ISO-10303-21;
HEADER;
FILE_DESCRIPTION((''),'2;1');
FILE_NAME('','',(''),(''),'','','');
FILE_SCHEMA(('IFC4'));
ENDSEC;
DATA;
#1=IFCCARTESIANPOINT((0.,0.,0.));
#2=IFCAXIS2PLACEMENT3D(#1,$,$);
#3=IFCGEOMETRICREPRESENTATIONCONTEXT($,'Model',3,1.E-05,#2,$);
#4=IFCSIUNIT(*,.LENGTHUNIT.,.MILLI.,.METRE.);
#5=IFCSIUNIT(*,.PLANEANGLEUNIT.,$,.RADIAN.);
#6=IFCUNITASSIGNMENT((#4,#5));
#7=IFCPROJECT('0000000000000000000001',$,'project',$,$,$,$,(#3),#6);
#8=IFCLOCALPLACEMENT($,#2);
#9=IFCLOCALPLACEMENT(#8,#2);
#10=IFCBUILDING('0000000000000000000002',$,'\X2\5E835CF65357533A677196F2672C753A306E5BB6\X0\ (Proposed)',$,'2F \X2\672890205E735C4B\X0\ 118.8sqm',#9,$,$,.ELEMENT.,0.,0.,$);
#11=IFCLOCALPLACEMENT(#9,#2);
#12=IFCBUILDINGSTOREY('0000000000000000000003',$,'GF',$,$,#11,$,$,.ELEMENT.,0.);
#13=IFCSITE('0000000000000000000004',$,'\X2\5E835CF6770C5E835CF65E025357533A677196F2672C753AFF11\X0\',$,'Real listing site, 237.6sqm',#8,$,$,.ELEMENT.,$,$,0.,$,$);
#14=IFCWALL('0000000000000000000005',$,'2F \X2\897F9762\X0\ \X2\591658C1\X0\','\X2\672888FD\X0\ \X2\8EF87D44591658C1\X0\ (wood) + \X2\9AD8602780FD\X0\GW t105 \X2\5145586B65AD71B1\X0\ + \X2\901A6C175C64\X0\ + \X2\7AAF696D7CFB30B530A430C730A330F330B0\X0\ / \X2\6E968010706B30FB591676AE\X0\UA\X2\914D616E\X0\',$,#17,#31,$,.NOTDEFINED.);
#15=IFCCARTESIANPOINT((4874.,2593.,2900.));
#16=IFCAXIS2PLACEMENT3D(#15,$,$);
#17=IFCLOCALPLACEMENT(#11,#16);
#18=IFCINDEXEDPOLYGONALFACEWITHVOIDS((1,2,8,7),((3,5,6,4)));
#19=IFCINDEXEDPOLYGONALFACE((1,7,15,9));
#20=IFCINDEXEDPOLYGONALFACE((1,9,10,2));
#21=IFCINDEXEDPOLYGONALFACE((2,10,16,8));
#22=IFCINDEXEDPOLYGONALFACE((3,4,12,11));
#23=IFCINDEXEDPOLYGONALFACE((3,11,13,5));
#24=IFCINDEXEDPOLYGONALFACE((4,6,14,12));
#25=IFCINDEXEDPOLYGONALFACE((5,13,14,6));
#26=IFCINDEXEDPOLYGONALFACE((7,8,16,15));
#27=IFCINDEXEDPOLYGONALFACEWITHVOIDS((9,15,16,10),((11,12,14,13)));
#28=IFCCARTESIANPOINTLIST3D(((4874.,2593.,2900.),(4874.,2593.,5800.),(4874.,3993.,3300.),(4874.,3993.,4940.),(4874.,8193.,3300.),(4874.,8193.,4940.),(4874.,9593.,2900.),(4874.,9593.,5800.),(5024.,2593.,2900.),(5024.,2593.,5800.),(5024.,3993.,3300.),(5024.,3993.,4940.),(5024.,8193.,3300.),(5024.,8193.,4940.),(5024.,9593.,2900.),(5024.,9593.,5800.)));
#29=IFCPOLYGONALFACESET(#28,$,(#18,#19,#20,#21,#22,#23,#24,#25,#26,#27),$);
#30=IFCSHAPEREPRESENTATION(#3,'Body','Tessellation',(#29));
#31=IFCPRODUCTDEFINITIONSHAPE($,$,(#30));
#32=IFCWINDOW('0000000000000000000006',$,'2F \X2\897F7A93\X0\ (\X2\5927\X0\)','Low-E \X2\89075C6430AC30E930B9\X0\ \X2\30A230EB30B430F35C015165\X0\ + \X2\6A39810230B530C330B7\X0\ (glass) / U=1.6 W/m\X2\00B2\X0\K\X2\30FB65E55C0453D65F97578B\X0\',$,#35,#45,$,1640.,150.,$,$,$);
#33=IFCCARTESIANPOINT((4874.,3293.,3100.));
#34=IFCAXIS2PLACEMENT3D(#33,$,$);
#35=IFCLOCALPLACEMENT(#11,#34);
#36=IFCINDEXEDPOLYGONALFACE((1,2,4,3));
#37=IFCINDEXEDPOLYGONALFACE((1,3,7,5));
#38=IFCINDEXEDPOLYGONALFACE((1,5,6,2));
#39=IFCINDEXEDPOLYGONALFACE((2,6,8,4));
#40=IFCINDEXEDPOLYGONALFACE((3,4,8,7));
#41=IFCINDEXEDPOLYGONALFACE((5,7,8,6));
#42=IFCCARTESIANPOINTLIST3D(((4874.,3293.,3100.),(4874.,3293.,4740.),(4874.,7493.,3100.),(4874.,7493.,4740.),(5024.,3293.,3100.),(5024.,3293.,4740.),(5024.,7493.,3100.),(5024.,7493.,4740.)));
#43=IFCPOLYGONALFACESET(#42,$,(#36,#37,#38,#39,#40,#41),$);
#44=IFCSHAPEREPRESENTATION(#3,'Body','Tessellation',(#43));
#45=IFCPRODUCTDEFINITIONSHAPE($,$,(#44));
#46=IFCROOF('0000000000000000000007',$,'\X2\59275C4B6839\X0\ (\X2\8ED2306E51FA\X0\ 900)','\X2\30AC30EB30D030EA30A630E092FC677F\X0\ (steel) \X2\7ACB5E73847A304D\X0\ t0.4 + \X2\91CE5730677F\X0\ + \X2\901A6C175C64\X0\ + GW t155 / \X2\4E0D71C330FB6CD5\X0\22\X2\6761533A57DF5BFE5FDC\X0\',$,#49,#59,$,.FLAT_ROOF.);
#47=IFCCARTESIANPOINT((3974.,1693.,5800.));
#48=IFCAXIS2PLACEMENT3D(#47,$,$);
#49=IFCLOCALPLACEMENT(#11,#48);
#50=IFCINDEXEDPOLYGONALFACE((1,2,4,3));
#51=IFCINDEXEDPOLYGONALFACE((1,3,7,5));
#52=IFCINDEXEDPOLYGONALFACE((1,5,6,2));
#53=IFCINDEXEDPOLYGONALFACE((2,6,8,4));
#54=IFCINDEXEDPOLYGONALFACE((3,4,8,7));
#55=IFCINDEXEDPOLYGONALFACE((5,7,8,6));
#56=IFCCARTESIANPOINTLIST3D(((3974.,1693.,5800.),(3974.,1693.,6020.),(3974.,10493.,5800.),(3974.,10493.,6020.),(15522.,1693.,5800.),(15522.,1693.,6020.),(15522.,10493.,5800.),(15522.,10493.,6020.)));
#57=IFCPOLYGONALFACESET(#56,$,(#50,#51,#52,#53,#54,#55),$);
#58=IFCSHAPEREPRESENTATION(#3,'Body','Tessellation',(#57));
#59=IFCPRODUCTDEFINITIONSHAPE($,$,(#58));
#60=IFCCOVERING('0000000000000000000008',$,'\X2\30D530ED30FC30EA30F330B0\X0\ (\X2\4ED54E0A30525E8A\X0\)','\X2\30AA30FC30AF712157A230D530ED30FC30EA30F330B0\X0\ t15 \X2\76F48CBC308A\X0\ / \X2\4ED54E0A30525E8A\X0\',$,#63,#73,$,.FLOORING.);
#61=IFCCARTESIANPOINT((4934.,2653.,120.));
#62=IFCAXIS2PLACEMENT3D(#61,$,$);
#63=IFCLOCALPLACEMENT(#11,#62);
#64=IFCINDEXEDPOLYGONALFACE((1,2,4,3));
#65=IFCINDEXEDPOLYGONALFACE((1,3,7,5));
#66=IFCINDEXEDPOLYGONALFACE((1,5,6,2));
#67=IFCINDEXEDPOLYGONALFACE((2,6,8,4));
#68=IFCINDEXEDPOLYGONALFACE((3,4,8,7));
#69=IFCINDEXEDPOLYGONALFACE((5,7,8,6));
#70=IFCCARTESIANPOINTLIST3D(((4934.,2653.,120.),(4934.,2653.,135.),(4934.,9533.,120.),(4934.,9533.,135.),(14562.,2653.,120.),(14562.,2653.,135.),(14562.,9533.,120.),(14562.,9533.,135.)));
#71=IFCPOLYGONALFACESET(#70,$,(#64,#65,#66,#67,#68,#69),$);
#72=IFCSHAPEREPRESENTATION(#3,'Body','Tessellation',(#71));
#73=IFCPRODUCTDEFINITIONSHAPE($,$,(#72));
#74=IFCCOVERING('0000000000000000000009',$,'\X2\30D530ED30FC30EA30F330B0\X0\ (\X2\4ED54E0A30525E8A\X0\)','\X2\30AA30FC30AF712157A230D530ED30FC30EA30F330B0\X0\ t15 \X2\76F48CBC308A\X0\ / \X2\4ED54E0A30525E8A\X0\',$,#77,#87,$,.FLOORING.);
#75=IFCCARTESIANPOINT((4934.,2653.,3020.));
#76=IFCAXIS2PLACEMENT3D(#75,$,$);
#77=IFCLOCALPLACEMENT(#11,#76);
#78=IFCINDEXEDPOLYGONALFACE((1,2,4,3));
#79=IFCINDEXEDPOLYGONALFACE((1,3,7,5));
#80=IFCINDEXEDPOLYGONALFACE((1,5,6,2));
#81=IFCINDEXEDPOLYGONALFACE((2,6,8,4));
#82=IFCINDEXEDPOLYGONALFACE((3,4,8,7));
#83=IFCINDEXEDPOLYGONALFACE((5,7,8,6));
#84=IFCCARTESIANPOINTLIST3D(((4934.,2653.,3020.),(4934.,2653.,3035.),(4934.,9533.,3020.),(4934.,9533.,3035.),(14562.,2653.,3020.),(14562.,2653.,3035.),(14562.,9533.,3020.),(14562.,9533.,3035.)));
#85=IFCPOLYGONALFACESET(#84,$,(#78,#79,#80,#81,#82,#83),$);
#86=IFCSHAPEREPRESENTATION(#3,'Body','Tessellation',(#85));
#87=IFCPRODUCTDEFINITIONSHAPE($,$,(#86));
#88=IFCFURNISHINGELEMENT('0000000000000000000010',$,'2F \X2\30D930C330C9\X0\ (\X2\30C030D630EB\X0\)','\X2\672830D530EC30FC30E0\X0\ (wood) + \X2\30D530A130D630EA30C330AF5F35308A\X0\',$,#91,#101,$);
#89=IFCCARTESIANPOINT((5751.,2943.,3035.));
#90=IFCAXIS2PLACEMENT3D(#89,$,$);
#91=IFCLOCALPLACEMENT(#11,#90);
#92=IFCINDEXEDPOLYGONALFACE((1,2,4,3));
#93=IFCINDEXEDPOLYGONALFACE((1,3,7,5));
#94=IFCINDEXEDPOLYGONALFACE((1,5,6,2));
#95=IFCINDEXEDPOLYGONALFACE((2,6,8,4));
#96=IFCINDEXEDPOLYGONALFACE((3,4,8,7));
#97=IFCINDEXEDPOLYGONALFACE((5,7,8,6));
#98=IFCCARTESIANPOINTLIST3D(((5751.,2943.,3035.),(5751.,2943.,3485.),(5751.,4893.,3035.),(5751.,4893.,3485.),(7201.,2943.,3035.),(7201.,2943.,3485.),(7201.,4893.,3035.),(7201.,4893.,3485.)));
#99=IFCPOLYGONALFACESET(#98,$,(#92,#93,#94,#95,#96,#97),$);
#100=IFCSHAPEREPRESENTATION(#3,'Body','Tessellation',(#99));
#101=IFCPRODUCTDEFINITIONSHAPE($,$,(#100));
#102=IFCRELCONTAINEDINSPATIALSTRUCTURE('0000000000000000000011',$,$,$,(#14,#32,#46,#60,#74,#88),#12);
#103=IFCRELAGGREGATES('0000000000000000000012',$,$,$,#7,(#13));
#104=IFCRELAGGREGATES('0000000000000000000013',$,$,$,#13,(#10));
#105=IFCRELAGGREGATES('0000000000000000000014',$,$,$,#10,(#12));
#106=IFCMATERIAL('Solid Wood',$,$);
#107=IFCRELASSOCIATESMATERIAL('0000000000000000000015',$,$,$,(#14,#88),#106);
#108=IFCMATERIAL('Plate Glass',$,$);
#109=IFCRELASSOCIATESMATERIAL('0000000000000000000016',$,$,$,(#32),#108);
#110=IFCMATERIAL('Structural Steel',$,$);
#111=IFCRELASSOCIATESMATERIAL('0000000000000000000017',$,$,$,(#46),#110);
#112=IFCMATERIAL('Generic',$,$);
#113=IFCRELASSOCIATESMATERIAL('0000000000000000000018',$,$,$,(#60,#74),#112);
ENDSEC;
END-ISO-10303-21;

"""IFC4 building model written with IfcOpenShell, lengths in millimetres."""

from ifc_helpers import new_model, si_unit, frame, frame_2d, origin, place, context, project, spatial, rectangle, extrude, material, element, fill, save


model = new_model("IFC4")

# Units and contexts
model_context = context("Model", 3, precision=1e-05, world=origin())
ifc_project = project(units=[si_unit("LENGTHUNIT", "METRE", prefix="MILLI"), si_unit("PLANEANGLEUNIT", "RADIAN")], contexts=[model_context])

# Site, building, storey
site_placement = place(None, origin())
site = spatial("IfcSite", under=ifc_project, at=site_placement, Name="広島県広島市南区東雲本町１", ObjectType="Real listing site, 237.6sqm", CompositionType="ELEMENT", RefElevation=0.0)
building_placement = place(site_placement, origin())
building = spatial("IfcBuilding", under=site, at=building_placement, Name="広島南区東雲本町の家 (Proposed)", ObjectType="2F 木造平屋 118.8sqm", CompositionType="ELEMENT", ElevationOfRefHeight=0.0, ElevationOfTerrain=0.0)
storey_placement = place(building_placement, origin())
storey = spatial("IfcBuildingStorey", under=building, at=storey_placement, Name="GF", CompositionType="ELEMENT", Elevation=0.0)

# Shared definitions
ifc_material_1 = material(Name="Solid Wood")

# Shared definitions
ifc_material_2 = material(Name="Plate Glass")

# Wall, opening, window
wall_1_placement = place(storey_placement, frame((4874.0, 2593.0, 2900.0)))
wall_1 = element("IfcWall", 1, at=wall_1_placement, inside=storey, material=ifc_material_1, Name="2F 西面 外壁", Description="木製 軸組外壁 (wood) + 高性能GW t105 充填断熱 + 通気層 + 窯業系サイディング / 準耐火・外皮UA配慮", PredefinedType="NOTDEFINED", context=model_context, shape_type="SweptSolid", body=[
    extrude(rectangle(XDim=150.0, YDim=7000.0, at=frame_2d((75.0, 3500.0))), frame((4874.0, 2593.0, 2900.0)), (0.0, 0.0, 1.0), 2900.0),
])
opening_1_placement = place(storey_placement, frame((4874.0, 3293.0, 3100.0)))
opening_1 = element("IfcOpeningElement", 2, at=opening_1_placement, cuts=wall_1, PredefinedType="NOTDEFINED", context=model_context, shape_type="SweptSolid", body=[
    extrude(rectangle(XDim=150.0, YDim=4200.0, at=frame_2d((75.0, 2100.0))), frame((4874.0, 3293.0, 3100.0)), (0.0, 0.0, 1.0), 1640.0),
])
window_1_placement = place(storey_placement, frame((4874.0, 3293.0, 3100.0)))
window_1 = element("IfcWindow", 3, at=window_1_placement, inside=storey, material=ifc_material_2, Name="2F 西窓 (大)", Description="Low-E 複層ガラス アルゴン封入 + 樹脂サッシ (glass) / U=1.6 W/m²K・日射取得型", OverallHeight=1640.0, OverallWidth=150.0, context=model_context, shape_type="SweptSolid", body=[
    extrude(rectangle(XDim=150.0, YDim=4200.0, at=frame_2d((75.0, 2100.0))), frame((4874.0, 3293.0, 3100.0)), (0.0, 0.0, 1.0), 1640.0),
])
fill(opening_1, window_1)

# Roof
ifc_material_3 = material(Name="Structural Steel")
roof_placement = place(storey_placement, frame((3974.0, 1693.0, 5800.0)))
element("IfcRoof", 4, at=roof_placement, inside=storey, material=ifc_material_3, Name="大屋根 (軒の出 900)", Description="ガルバリウム鋼板 (steel) 立平葺き t0.4 + 野地板 + 通気層 + GW t155 / 不燃・法22条区域対応", PredefinedType="FLAT_ROOF", context=model_context, shape_type="SweptSolid", body=[
    extrude(rectangle(XDim=11548.0, YDim=8800.0, at=frame_2d((5774.0, 4400.0))), frame((3974.0, 1693.0, 5800.0)), (0.0, 0.0, 1.0), 220.0),
])

# Coverings
ifc_material_4 = material(Name="Generic")
covering_1_placement = place(storey_placement, frame((4934.0, 2653.0, 120.0)))
element("IfcCovering", 5, at=covering_1_placement, inside=storey, material=ifc_material_4, Name="フローリング (仕上げ床)", Description="オーク無垢フローリング t15 直貼り / 仕上げ床", PredefinedType="FLOORING", context=model_context, shape_type="SweptSolid", body=[
    extrude(rectangle(XDim=9628.0, YDim=6880.0, at=frame_2d((4814.0, 3440.0))), frame((4934.0, 2653.0, 120.0)), (0.0, 0.0, 1.0), 15.0),
])
covering_2_placement = place(storey_placement, frame((4934.0, 2653.0, 3020.0)))
element("IfcCovering", 6, at=covering_2_placement, inside=storey, material=ifc_material_4, Name="フローリング (仕上げ床)", Description="オーク無垢フローリング t15 直貼り / 仕上げ床", PredefinedType="FLOORING", context=model_context, shape_type="SweptSolid", body=[
    extrude(rectangle(XDim=9628.0, YDim=6880.0, at=frame_2d((4814.0, 3440.0))), frame((4934.0, 2653.0, 3020.0)), (0.0, 0.0, 1.0), 15.0),
])

# Furnishing element
furnishing_placement = place(storey_placement, frame((5751.0, 2943.0, 3035.0)))
element("IfcFurnishingElement", 7, at=furnishing_placement, inside=storey, material=ifc_material_1, Name="2F ベッド (ダブル)", Description="木フレーム (wood) + ファブリック張り", context=model_context, shape_type="SweptSolid", body=[
    extrude(rectangle(XDim=1450.0, YDim=1950.0, at=frame_2d((725.0, 975.0))), frame((5751.0, 2943.0, 3035.0)), (0.0, 0.0, 1.0), 450.0),
])

save(model, "model.ifc")
